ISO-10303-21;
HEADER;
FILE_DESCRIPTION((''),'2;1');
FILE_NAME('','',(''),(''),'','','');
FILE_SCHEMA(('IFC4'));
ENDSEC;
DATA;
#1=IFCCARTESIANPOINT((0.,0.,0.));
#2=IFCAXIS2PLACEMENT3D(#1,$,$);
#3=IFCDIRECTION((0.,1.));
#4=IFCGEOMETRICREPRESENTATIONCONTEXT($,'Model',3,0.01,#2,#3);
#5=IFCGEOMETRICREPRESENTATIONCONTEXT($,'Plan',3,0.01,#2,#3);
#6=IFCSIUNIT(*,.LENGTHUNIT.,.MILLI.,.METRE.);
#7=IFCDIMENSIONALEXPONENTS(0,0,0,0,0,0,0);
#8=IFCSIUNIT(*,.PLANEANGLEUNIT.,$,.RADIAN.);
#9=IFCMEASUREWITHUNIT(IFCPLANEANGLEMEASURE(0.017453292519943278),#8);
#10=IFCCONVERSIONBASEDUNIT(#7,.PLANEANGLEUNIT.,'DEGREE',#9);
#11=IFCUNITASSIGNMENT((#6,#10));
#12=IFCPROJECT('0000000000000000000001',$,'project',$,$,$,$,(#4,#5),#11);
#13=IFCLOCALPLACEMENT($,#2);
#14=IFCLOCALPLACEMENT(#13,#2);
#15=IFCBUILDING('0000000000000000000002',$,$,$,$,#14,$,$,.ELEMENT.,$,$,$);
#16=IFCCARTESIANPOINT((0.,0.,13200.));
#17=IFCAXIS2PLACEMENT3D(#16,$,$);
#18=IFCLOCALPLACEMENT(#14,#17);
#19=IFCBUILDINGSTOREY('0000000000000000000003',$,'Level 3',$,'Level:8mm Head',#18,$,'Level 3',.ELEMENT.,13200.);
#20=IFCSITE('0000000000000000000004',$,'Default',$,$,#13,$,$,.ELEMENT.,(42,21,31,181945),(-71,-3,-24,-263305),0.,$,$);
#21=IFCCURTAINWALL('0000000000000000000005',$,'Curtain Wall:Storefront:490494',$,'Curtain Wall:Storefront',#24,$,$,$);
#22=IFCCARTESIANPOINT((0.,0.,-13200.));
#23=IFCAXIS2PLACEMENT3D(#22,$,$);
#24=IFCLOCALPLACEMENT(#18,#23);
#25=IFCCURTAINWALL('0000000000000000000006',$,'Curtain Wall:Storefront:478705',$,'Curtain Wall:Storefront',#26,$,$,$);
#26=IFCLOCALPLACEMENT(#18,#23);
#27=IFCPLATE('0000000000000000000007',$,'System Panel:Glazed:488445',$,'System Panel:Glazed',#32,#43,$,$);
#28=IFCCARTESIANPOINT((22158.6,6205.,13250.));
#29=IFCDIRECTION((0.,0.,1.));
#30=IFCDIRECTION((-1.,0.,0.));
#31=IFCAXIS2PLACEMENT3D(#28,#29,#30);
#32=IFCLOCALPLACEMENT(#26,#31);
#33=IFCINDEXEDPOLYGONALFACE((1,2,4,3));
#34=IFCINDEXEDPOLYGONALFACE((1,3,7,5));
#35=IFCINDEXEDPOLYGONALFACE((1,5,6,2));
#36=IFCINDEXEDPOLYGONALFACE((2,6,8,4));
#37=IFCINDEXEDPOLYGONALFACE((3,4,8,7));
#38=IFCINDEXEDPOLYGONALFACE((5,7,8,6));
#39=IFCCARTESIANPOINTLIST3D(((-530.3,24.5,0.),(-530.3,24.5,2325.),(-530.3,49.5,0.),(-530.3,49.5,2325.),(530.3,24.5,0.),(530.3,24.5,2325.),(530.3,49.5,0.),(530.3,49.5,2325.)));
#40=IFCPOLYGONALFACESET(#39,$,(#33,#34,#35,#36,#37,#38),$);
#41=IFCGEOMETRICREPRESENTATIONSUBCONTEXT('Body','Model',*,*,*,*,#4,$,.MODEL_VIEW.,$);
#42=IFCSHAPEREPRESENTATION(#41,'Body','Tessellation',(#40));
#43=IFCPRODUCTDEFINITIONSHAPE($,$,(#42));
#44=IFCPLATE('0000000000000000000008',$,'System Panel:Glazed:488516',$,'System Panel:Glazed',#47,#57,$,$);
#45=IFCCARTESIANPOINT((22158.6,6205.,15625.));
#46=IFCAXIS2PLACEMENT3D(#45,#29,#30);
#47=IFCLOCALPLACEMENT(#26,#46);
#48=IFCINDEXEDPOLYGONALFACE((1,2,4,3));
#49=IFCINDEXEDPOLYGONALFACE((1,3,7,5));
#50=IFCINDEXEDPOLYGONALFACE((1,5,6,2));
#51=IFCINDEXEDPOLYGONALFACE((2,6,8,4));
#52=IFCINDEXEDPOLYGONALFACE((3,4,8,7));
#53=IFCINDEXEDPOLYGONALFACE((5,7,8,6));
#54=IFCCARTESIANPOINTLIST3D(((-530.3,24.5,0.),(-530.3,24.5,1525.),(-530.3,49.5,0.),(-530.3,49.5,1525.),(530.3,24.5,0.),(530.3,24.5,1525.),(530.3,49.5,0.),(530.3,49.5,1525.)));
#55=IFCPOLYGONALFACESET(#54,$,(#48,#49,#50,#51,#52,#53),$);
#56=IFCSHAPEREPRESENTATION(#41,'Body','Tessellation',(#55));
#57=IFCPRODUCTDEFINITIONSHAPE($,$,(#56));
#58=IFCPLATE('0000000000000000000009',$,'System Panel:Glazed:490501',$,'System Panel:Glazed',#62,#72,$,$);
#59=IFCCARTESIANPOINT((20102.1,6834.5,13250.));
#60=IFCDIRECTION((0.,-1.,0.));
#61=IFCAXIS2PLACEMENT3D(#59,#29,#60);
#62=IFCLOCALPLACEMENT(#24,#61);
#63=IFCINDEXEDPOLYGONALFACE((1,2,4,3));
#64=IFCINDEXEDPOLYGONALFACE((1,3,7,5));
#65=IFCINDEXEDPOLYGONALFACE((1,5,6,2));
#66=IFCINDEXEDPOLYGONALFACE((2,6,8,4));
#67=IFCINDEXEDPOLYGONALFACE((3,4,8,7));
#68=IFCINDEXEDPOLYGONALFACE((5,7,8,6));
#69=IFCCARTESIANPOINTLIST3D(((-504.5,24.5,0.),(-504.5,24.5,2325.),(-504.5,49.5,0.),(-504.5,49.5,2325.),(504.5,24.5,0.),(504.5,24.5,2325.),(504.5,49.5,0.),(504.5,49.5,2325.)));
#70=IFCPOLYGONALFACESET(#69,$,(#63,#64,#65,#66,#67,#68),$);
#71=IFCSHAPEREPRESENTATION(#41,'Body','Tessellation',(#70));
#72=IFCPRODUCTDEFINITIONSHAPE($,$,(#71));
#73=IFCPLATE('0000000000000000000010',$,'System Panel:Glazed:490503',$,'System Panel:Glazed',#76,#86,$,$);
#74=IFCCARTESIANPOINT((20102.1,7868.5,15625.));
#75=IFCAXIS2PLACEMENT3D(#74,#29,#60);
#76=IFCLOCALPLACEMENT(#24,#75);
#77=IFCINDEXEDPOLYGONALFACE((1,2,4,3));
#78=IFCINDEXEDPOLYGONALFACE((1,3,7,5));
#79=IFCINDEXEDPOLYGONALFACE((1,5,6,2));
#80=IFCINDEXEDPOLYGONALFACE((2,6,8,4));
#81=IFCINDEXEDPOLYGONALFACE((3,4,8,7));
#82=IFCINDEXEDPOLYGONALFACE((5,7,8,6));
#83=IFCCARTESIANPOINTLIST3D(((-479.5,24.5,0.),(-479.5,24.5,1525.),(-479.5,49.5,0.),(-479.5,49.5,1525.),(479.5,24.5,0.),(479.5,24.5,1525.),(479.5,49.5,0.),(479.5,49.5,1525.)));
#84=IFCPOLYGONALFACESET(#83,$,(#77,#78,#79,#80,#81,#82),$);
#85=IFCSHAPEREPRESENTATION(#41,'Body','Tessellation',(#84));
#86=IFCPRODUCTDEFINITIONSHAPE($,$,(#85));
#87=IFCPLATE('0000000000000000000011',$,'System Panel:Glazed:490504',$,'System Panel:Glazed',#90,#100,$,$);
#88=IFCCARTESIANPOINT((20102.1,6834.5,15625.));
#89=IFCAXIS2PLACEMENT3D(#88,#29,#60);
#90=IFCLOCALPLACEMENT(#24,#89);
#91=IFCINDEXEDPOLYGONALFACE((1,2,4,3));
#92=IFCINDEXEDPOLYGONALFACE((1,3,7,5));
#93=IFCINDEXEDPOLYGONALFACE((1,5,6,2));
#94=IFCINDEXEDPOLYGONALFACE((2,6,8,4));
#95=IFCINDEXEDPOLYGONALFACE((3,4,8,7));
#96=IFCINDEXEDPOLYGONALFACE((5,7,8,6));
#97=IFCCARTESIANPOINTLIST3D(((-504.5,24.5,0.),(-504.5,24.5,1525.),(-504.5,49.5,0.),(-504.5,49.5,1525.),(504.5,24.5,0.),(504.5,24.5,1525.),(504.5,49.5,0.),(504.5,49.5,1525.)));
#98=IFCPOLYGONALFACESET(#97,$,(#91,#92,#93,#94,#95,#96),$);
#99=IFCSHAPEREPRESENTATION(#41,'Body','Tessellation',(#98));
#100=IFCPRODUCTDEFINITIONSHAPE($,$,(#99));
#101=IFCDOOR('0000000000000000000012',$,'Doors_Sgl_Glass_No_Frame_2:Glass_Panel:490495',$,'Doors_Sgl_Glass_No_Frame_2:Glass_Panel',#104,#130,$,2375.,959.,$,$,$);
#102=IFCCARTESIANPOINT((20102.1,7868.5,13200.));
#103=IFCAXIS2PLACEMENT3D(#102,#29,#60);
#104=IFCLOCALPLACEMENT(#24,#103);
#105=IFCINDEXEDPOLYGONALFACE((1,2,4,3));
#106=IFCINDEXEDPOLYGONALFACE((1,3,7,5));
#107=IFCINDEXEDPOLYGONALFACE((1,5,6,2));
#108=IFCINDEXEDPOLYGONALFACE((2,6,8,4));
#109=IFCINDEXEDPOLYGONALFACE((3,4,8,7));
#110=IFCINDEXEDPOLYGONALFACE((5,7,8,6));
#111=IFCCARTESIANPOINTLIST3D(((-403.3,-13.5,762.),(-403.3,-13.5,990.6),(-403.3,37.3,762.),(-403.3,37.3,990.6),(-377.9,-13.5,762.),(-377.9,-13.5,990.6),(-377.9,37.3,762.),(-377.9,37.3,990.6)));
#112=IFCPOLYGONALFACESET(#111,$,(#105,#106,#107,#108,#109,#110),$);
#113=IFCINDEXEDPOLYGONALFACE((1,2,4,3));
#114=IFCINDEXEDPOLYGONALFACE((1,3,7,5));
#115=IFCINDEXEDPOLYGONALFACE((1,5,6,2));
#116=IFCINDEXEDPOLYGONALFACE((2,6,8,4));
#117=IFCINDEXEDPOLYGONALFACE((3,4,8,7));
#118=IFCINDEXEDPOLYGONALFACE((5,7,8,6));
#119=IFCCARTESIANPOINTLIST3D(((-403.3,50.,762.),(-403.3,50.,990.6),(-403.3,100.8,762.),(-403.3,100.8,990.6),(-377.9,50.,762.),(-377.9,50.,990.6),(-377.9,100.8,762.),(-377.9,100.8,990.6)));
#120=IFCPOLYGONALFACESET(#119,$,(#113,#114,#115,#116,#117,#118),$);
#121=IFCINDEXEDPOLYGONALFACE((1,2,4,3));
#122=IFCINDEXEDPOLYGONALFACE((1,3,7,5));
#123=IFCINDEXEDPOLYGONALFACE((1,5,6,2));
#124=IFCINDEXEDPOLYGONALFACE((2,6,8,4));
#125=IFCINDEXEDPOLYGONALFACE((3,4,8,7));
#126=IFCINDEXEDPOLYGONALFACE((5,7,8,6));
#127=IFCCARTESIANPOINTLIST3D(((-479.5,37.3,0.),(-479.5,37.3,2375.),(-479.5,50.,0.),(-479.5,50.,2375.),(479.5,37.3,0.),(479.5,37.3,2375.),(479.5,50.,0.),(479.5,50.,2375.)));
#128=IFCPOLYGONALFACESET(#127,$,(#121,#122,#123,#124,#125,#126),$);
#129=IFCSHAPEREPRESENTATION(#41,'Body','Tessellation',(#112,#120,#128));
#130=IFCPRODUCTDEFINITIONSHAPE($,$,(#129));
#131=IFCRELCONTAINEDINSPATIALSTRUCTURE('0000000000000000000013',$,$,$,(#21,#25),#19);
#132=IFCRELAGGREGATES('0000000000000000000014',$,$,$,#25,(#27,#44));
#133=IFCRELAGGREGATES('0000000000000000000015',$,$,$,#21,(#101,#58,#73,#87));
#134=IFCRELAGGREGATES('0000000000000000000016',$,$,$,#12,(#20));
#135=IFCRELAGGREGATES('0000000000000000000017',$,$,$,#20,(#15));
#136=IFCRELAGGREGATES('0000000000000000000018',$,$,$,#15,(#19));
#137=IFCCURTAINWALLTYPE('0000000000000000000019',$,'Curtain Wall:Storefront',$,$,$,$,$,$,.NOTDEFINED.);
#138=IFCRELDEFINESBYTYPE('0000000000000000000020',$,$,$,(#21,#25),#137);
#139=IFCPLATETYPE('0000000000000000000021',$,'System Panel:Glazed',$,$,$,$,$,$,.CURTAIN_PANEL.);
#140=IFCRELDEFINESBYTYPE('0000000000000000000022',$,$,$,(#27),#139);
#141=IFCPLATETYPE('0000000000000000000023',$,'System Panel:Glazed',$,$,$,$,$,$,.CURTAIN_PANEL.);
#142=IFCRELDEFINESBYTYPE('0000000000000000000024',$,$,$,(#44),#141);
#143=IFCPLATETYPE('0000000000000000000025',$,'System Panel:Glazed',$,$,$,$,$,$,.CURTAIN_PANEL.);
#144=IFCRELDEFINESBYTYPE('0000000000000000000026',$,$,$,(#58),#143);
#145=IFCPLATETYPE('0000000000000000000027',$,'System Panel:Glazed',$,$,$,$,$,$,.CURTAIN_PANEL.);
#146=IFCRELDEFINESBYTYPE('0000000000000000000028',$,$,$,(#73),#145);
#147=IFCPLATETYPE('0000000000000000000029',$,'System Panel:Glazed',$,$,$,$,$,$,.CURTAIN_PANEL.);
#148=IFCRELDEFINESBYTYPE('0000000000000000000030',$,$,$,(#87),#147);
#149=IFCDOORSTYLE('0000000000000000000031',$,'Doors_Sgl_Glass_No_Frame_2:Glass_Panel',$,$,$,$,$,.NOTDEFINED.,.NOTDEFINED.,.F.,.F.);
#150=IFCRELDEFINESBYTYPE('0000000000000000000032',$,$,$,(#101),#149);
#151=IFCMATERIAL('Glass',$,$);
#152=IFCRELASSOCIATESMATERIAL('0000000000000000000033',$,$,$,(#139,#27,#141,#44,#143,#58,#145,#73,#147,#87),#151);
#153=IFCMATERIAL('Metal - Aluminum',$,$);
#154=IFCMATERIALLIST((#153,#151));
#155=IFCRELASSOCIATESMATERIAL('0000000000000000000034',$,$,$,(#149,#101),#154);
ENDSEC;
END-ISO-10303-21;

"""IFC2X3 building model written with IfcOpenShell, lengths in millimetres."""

from ifc_helpers import new_model, entity, si_unit, converted_unit, direction, frame, frame_2d, origin, origin_2d_with_axis, place, context, subcontext, project, spatial, rectangle, extrude, source, transform, mapped, material, material_list, type_object, type_shapes, element, aggregate, save


model = new_model("IFC2X3")

# Units and contexts
model_context = context("Model", 3, precision=0.01, world=origin(), true_north=direction((0.0, 1.0)))
plan_context = context("Plan", 3, precision=0.01, world=origin(), true_north=direction((0.0, 1.0)))
body_context = subcontext(model_context, "Body", "Model", "MODEL_VIEW")
ifc_project = project(units=[si_unit("LENGTHUNIT", "METRE", prefix="MILLI"), converted_unit("PLANEANGLEUNIT", "DEGREE", entity("IfcPlaneAngleMeasure", 0.017453292519943278), si_unit("PLANEANGLEUNIT", "RADIAN"), dimensions=[0, 0, 0, 0, 0, 0, 0])], contexts=[model_context, plan_context])

# Site, building, storey
site_placement = place(None, origin())
site = spatial("IfcSite", under=ifc_project, at=site_placement, Name="Default", CompositionType="ELEMENT", RefLatitude=(42, 21, 31, 181945), RefLongitude=(-71, -3, -24, -263305), RefElevation=0.0)
building_placement = place(site_placement, origin())
building = spatial("IfcBuilding", under=site, at=building_placement, CompositionType="ELEMENT")
storey_placement = place(building_placement, frame((0.0, 0.0, 13200.0)))
storey = spatial("IfcBuildingStorey", under=building, at=storey_placement, Name="Level 3", ObjectType="Level:8mm Head", LongName="Level 3", CompositionType="ELEMENT", Elevation=13200.0)

# Curtain wall
curtain_wall_type = type_object("IfcCurtainWallType", Name="Curtain Wall:Storefront", PredefinedType="NOTDEFINED")
curtain_wall_1_placement = place(storey_placement, frame((0.0, 0.0, -13200.0)))
curtain_wall_1 = element("IfcCurtainWall", 1, at=curtain_wall_1_placement, inside=storey, type_object=curtain_wall_type, Name="Curtain Wall:Storefront:490494", ObjectType="Curtain Wall:Storefront")

# Curtain wall
curtain_wall_2_placement = place(storey_placement, frame((0.0, 0.0, -13200.0)))
curtain_wall_2 = element("IfcCurtainWall", 2, at=curtain_wall_2_placement, inside=storey, type_object=curtain_wall_type, Name="Curtain Wall:Storefront:478705", ObjectType="Curtain Wall:Storefront")

# Plates
ifc_material_1 = material(Name="Glass")
plate_type_1 = type_object("IfcPlateType", Name="System Panel:Glazed", PredefinedType="CURTAIN_PANEL", material=ifc_material_1)
shared_shape_1 = source(origin(), body_context, "Body", "SweptSolid", [
    extrude(rectangle(XDim=25.0, YDim=1060.7, at=origin_2d_with_axis()), frame((0.0, 37.0, 0.0), z_axis=(0.0, 0.0, 1.0), x_axis=(0.0, 1.0, 0.0)), (0.0, 0.0, 1.0), 2325.0),
])
type_shapes(plate_type_1, [shared_shape_1])
plate_1_placement = place(curtain_wall_2_placement, frame((22158.6, 6205.0, 13250.0), z_axis=(0.0, 0.0, 1.0), x_axis=(-1.0, 0.0, 0.0)))
plate_1 = element("IfcPlate", 3, at=plate_1_placement, type_object=plate_type_1, material=ifc_material_1, Name="System Panel:Glazed:488445", ObjectType="System Panel:Glazed", context=body_context, shape_type="MappedRepresentation", body=[
    mapped(shared_shape_1, transform((0.0, 0.0, 0.0), scale=1.0)),
])
plate_type_2 = type_object("IfcPlateType", Name="System Panel:Glazed", PredefinedType="CURTAIN_PANEL", material=ifc_material_1)
shared_shape_2 = source(origin(), body_context, "Body", "SweptSolid", [
    extrude(rectangle(XDim=25.0, YDim=1060.7, at=origin_2d_with_axis()), frame((0.0, 37.0, 0.0), z_axis=(0.0, 0.0, 1.0), x_axis=(0.0, 1.0, 0.0)), (0.0, 0.0, 1.0), 1525.0),
])
type_shapes(plate_type_2, [shared_shape_2])
plate_2_placement = place(curtain_wall_2_placement, frame((22158.6, 6205.0, 15625.0), z_axis=(0.0, 0.0, 1.0), x_axis=(-1.0, 0.0, 0.0)))
plate_2 = element("IfcPlate", 4, at=plate_2_placement, type_object=plate_type_2, material=ifc_material_1, Name="System Panel:Glazed:488516", ObjectType="System Panel:Glazed", context=body_context, shape_type="MappedRepresentation", body=[
    mapped(shared_shape_2, transform((0.0, 0.0, 0.0), scale=1.0)),
])
aggregate(curtain_wall_2, [plate_1, plate_2])
plate_type_3 = type_object("IfcPlateType", Name="System Panel:Glazed", PredefinedType="CURTAIN_PANEL", material=ifc_material_1)
shared_shape_3 = source(origin(), body_context, "Body", "SweptSolid", [
    extrude(rectangle(XDim=25.0, YDim=1009.0, at=origin_2d_with_axis()), frame((0.0, 37.0, 0.0), z_axis=(0.0, 0.0, 1.0), x_axis=(0.0, 1.0, 0.0)), (0.0, 0.0, 1.0), 2325.0),
])
type_shapes(plate_type_3, [shared_shape_3])
plate_3_placement = place(curtain_wall_1_placement, frame((20102.1, 6834.5, 13250.0), z_axis=(0.0, 0.0, 1.0), x_axis=(0.0, -1.0, 0.0)))
plate_3 = element("IfcPlate", 5, at=plate_3_placement, type_object=plate_type_3, material=ifc_material_1, Name="System Panel:Glazed:490501", ObjectType="System Panel:Glazed", context=body_context, shape_type="MappedRepresentation", body=[
    mapped(shared_shape_3, transform((0.0, 0.0, 0.0), scale=1.0)),
])
plate_type_4 = type_object("IfcPlateType", Name="System Panel:Glazed", PredefinedType="CURTAIN_PANEL", material=ifc_material_1)
shared_shape_4 = source(origin(), body_context, "Body", "SweptSolid", [
    extrude(rectangle(XDim=25.0, YDim=959.0, at=origin_2d_with_axis()), frame((0.0, 37.0, 0.0), z_axis=(0.0, 0.0, 1.0), x_axis=(0.0, 1.0, 0.0)), (0.0, 0.0, 1.0), 1525.0),
])
type_shapes(plate_type_4, [shared_shape_4])
plate_4_placement = place(curtain_wall_1_placement, frame((20102.1, 7868.5, 15625.0), z_axis=(0.0, 0.0, 1.0), x_axis=(0.0, -1.0, 0.0)))
plate_4 = element("IfcPlate", 6, at=plate_4_placement, type_object=plate_type_4, material=ifc_material_1, Name="System Panel:Glazed:490503", ObjectType="System Panel:Glazed", context=body_context, shape_type="MappedRepresentation", body=[
    mapped(shared_shape_4, transform((0.0, 0.0, 0.0), scale=1.0)),
])
plate_type_5 = type_object("IfcPlateType", Name="System Panel:Glazed", PredefinedType="CURTAIN_PANEL", material=ifc_material_1)
shared_shape_5 = source(origin(), body_context, "Body", "SweptSolid", [
    extrude(rectangle(XDim=25.0, YDim=1009.0, at=origin_2d_with_axis()), frame((0.0, 37.0, 0.0), z_axis=(0.0, 0.0, 1.0), x_axis=(0.0, 1.0, 0.0)), (0.0, 0.0, 1.0), 1525.0),
])
type_shapes(plate_type_5, [shared_shape_5])
plate_5_placement = place(curtain_wall_1_placement, frame((20102.1, 6834.5, 15625.0), z_axis=(0.0, 0.0, 1.0), x_axis=(0.0, -1.0, 0.0)))
plate_5 = element("IfcPlate", 7, at=plate_5_placement, type_object=plate_type_5, material=ifc_material_1, Name="System Panel:Glazed:490504", ObjectType="System Panel:Glazed", context=body_context, shape_type="MappedRepresentation", body=[
    mapped(shared_shape_5, transform((0.0, 0.0, 0.0), scale=1.0)),
])

# Door
ifc_material_2 = material(Name="Metal - Aluminum")
ifc_material_list = material_list([ifc_material_2, ifc_material_1])
door_style = type_object("IfcDoorStyle", Name="Doors_Sgl_Glass_No_Frame_2:Glass_Panel", ConstructionType="NOTDEFINED", OperationType="NOTDEFINED", ParameterTakesPrecedence=False, Sizeable=False, material=ifc_material_list)
shared_shape_6 = source(origin(), body_context, "Body", "SweptSolid", [
    extrude(rectangle(XDim=50.8, YDim=25.4, at=origin_2d_with_axis()), frame((-390.6, 11.9, 762.0), z_axis=(0.0, 0.0, 1.0), x_axis=(0.0, 1.0, 0.0)), (0.0, 0.0, 1.0), 228.6),
    extrude(rectangle(XDim=50.8, YDim=25.4, at=frame_2d((0.0, 0.0), x_axis=(1.0, 0.0))), frame((-390.6, 75.4, 762.0), z_axis=(0.0, 0.0, 1.0), x_axis=(0.0, -1.0, 0.0)), (0.0, 0.0, 1.0), 228.6),
    extrude(rectangle(XDim=959.0, YDim=12.7, at=frame_2d((0.0, 0.0), x_axis=(1.0, 0.0))), frame((0.0, 43.7, 0.0), z_axis=(0.0, 0.0, 1.0), x_axis=(-1.0, 0.0, 0.0)), (0.0, 0.0, 1.0), 2375.0),
])
type_shapes(door_style, [shared_shape_6])
door_placement = place(curtain_wall_1_placement, frame((20102.1, 7868.5, 13200.0), z_axis=(0.0, 0.0, 1.0), x_axis=(0.0, -1.0, 0.0)))
door = element("IfcDoor", 8, at=door_placement, type_object=door_style, material=ifc_material_list, Name="Doors_Sgl_Glass_No_Frame_2:Glass_Panel:490495", ObjectType="Doors_Sgl_Glass_No_Frame_2:Glass_Panel", OverallHeight=2375.0, OverallWidth=959.0, context=body_context, shape_type="MappedRepresentation", body=[
    mapped(shared_shape_6, transform((0.0, 0.0, 0.0), scale=1.0)),
])
aggregate(curtain_wall_1, [door, plate_3, plate_4, plate_5])

save(model, "model.ifc")
